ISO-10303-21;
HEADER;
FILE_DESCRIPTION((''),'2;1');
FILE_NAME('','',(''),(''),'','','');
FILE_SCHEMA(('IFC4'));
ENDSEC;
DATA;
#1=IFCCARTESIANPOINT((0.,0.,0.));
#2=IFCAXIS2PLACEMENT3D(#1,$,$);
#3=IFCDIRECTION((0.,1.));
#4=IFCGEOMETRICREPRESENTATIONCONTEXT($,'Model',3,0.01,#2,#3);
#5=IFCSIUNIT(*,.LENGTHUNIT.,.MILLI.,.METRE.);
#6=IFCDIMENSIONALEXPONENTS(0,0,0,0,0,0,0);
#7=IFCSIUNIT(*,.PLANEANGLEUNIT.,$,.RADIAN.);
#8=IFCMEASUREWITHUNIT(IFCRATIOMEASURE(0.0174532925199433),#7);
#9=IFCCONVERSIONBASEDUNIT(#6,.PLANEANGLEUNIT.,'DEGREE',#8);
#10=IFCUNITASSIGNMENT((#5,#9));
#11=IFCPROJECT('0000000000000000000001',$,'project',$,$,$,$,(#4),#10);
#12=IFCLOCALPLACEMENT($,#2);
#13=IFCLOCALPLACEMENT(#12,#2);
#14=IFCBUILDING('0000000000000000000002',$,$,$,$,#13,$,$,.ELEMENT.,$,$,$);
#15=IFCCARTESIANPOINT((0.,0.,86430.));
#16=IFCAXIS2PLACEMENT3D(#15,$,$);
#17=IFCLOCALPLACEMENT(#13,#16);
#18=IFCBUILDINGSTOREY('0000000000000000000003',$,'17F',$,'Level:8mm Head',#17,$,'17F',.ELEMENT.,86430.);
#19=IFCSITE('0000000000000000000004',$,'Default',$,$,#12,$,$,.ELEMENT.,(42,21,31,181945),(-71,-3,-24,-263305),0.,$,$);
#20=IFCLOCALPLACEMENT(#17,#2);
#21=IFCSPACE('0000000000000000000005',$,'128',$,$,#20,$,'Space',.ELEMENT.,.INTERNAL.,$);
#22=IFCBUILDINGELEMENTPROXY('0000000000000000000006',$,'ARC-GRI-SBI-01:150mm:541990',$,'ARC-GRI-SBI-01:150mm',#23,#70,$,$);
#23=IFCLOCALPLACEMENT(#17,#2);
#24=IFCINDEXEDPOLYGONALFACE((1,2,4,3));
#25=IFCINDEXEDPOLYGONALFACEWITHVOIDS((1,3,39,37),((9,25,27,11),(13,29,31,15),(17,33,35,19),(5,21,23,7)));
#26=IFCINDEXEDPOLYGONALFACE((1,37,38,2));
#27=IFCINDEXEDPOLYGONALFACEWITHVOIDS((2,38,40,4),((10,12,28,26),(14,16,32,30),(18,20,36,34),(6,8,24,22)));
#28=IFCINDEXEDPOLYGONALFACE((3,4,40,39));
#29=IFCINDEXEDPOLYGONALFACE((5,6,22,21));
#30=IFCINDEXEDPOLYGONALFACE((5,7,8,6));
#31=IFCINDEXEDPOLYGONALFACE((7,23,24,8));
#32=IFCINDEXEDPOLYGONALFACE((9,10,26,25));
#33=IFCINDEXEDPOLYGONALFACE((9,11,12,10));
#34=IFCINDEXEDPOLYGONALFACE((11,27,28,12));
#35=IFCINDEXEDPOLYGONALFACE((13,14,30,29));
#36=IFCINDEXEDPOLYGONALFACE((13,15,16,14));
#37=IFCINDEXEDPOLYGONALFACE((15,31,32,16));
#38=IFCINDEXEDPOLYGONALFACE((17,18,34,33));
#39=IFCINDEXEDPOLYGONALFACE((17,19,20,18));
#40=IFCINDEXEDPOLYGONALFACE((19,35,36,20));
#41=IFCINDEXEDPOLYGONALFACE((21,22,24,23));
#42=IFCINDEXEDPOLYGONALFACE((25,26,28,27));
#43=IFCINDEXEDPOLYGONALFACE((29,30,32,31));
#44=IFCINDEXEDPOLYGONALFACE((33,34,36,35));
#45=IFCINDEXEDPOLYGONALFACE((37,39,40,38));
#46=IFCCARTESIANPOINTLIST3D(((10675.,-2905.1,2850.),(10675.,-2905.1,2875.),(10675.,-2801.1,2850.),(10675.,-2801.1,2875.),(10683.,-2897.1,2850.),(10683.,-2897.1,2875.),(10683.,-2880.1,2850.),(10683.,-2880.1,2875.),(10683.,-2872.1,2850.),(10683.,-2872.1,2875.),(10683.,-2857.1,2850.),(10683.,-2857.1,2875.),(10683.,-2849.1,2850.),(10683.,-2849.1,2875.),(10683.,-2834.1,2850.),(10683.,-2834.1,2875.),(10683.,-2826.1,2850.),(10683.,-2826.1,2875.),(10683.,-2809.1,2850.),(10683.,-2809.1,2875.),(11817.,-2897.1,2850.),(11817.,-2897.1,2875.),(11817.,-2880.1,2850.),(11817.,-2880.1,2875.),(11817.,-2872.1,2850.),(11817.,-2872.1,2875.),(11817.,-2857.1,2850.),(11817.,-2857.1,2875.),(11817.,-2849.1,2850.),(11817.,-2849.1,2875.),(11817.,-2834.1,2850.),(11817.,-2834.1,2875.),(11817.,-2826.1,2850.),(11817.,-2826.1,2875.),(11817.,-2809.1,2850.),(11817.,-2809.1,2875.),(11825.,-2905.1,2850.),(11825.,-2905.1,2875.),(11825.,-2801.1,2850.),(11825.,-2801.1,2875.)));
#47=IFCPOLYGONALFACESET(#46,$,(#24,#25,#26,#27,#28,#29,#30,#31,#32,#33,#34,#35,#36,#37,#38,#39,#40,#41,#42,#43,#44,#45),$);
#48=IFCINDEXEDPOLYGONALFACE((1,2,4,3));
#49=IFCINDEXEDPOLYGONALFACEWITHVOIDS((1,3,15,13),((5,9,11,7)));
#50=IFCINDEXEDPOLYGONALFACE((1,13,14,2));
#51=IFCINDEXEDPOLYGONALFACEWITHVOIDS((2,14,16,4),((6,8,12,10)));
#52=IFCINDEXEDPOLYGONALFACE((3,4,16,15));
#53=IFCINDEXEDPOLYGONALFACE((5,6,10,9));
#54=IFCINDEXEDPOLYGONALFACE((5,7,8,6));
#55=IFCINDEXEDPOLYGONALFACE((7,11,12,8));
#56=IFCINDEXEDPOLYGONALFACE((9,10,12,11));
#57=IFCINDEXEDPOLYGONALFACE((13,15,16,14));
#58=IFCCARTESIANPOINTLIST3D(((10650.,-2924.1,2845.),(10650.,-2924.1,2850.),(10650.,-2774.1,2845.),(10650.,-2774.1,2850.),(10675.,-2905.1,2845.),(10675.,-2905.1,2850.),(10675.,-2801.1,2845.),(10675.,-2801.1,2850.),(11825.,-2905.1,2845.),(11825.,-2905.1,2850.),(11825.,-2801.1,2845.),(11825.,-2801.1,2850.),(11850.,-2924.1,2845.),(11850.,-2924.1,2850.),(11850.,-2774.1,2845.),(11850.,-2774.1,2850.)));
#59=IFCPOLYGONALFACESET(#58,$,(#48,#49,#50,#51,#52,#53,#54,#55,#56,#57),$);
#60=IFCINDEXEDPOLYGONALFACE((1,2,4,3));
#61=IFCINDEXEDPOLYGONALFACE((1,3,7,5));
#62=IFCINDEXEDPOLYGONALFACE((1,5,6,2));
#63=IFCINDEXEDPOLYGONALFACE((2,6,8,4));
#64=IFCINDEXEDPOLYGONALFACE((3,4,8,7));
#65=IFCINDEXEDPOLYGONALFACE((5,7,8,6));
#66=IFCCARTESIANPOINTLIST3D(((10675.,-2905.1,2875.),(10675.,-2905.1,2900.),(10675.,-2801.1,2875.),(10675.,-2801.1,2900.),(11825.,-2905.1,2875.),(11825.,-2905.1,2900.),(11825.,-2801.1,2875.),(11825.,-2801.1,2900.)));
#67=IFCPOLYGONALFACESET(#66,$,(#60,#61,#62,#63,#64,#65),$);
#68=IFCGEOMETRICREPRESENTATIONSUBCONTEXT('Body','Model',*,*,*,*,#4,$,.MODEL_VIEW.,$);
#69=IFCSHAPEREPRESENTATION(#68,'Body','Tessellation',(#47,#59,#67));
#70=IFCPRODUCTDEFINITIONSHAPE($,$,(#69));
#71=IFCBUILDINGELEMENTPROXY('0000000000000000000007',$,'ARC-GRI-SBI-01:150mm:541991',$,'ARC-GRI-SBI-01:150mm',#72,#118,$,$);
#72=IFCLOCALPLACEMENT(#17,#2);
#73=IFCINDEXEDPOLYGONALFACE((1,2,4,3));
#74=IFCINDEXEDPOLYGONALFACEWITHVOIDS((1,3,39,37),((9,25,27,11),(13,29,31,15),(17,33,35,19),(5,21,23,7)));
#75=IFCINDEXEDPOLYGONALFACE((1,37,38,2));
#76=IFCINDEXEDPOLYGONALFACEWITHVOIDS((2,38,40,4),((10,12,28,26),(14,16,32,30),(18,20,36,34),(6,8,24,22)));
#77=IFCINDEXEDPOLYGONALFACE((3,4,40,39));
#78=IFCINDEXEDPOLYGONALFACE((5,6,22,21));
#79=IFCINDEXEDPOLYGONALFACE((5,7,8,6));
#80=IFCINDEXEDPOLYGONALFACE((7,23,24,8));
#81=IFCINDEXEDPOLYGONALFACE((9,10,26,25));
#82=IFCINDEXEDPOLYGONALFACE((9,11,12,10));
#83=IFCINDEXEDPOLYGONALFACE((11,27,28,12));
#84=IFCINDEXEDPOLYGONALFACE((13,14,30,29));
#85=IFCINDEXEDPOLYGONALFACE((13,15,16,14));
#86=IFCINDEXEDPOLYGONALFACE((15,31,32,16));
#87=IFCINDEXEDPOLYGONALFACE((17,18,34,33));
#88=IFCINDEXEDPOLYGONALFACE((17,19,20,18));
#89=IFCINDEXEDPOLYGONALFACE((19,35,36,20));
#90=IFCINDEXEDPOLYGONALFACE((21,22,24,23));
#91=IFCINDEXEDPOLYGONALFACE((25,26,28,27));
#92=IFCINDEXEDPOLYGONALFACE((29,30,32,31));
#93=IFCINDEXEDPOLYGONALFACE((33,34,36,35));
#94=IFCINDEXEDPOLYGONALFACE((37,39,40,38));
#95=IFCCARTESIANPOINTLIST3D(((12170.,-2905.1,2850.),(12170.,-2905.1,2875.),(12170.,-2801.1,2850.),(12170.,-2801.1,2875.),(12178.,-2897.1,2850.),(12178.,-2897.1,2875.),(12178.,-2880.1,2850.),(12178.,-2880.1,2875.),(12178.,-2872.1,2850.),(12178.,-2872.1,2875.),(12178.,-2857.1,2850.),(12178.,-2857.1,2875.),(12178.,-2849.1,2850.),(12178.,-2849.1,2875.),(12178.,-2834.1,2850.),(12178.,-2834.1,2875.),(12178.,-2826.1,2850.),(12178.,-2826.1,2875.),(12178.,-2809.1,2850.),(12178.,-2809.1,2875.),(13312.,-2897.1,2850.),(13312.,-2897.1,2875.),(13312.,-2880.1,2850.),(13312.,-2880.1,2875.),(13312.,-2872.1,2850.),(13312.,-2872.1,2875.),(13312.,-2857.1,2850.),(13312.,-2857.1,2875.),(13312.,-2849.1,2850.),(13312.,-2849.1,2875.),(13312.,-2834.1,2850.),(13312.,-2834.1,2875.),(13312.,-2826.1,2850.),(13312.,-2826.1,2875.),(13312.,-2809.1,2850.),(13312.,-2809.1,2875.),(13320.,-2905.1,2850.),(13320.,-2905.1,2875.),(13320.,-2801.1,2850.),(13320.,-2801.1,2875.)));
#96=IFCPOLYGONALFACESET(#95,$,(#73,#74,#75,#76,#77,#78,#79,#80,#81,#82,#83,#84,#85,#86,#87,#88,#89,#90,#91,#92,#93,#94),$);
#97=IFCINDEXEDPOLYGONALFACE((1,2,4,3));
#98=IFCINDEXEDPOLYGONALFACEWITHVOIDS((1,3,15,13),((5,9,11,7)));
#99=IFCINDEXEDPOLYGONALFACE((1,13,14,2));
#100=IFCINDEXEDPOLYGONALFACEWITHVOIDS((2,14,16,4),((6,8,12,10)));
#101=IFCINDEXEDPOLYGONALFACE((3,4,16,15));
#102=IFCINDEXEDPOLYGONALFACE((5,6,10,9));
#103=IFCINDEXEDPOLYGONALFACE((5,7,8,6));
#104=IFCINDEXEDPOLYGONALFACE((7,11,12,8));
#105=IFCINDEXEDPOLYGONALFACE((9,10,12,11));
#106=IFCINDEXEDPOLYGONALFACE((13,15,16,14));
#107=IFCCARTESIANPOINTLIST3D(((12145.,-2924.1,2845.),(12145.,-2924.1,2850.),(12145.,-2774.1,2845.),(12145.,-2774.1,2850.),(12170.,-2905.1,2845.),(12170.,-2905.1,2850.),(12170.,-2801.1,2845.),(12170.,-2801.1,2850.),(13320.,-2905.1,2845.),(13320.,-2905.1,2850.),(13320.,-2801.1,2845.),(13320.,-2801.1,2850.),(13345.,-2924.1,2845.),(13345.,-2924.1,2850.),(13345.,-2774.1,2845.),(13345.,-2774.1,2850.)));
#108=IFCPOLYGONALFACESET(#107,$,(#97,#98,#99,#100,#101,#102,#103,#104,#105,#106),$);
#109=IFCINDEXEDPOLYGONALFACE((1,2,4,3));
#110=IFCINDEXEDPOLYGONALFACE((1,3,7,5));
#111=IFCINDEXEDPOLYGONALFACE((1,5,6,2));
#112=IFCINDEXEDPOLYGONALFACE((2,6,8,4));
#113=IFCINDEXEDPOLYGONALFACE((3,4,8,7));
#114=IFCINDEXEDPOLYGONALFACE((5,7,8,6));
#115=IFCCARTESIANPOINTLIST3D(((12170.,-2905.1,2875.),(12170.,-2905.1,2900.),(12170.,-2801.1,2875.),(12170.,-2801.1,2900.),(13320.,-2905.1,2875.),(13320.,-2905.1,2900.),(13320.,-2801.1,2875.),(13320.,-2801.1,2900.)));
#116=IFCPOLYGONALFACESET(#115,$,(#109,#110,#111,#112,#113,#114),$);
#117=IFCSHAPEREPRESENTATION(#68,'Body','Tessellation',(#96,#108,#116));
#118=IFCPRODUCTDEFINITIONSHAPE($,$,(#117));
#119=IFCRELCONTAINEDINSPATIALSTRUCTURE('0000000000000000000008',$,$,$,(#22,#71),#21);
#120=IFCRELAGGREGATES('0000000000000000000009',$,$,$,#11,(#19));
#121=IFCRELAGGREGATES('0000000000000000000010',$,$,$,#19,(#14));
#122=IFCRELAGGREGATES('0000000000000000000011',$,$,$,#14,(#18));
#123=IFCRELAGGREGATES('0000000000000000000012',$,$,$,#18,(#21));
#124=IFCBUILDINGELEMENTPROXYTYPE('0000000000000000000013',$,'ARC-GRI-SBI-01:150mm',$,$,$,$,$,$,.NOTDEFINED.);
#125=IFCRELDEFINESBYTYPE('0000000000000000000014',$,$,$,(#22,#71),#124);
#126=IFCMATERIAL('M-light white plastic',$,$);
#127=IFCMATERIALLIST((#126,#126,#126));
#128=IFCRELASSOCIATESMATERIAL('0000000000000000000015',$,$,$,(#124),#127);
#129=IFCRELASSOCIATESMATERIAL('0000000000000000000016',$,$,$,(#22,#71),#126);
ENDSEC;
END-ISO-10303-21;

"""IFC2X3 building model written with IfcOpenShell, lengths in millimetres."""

from ifc_helpers import new_model, entity, si_unit, converted_unit, direction, frame, origin, origin_2d_with_axis, place, context, subcontext, project, spatial, polyline, rectangle, outline, extrude, source, transform, mapped, material, material_list, type_object, type_shapes, element, save


model = new_model("IFC2X3")

# Units and contexts
model_context = context("Model", 3, precision=0.01, world=origin(), true_north=direction((0.0, 1.0)))
body_context = subcontext(model_context, "Body", "Model", "MODEL_VIEW")
ifc_project = project(units=[si_unit("LENGTHUNIT", "METRE", prefix="MILLI"), converted_unit("PLANEANGLEUNIT", "DEGREE", entity("IfcRatioMeasure", 0.0174532925199433), si_unit("PLANEANGLEUNIT", "RADIAN"), dimensions=[0, 0, 0, 0, 0, 0, 0])], contexts=[model_context])

# Site, building, storey
site_placement = place(None, origin())
site = spatial("IfcSite", under=ifc_project, at=site_placement, Name="Default", CompositionType="ELEMENT", RefLatitude=(42, 21, 31, 181945), RefLongitude=(-71, -3, -24, -263305), RefElevation=0.0)
building_placement = place(site_placement, origin())
building = spatial("IfcBuilding", under=site, at=building_placement, CompositionType="ELEMENT")
storey_placement = place(building_placement, frame((0.0, 0.0, 86430.0)))
storey = spatial("IfcBuildingStorey", under=building, at=storey_placement, Name="17F", ObjectType="Level:8mm Head", LongName="17F", CompositionType="ELEMENT", Elevation=86430.0)

# Shared definitions
space_placement = place(storey_placement, origin())
space = spatial("IfcSpace", under=storey, at=space_placement, Name="128", LongName="Space", CompositionType="ELEMENT", InteriorOrExteriorSpace="INTERNAL")

# Building element proxies
ifc_material_1 = material(Name="M-light white plastic")
ifc_material_list = material_list([ifc_material_1, ifc_material_1, ifc_material_1])
building_element_proxy_type = type_object("IfcBuildingElementProxyType", Name="ARC-GRI-SBI-01:150mm", PredefinedType="NOTDEFINED", material=ifc_material_list)
shared_shape = source(origin(), body_context, "Body", "SweptSolid", [
    extrude(outline(polyline([(-575.0, -52.0), (575.0, -52.0), (575.0, 52.0), (-575.0, 52.0), (-575.0, -52.0)]), holes=[polyline([(-567.0, -44.0), (-567.0, -27.0), (567.0, -27.0), (567.0, -44.0), (-567.0, -44.0)]), polyline([(567.0, -4.0), (567.0, -19.0), (-567.0, -19.0), (-567.0, -4.0), (567.0, -4.0)]), polyline([(-567.0, 44.0), (567.0, 44.0), (567.0, 27.0), (-567.0, 27.0), (-567.0, 44.0)]), polyline([(567.0, 4.0), (-567.0, 4.0), (-567.0, 19.0), (567.0, 19.0), (567.0, 4.0)])]), frame((425.0, 4.0, 4000.0), z_axis=(0.0, 0.0, 1.0), x_axis=(-1.0, 0.0, 0.0)), (0.0, 0.0, 1.0), 25.0),
    extrude(outline(polyline([(-600.0, -75.0), (600.0, -75.0), (600.0, 75.0), (-600.0, 75.0), (-600.0, -75.0)]), holes=[polyline([(-575.0, -56.0), (-575.0, 48.0), (575.0, 48.0), (575.0, -56.0), (-575.0, -56.0)])]), frame((425.0, 0.0, 3995.0), z_axis=(0.0, 0.0, 1.0), x_axis=(-1.0, 0.0, 0.0)), (0.0, 0.0, 1.0), 5.0),
    extrude(rectangle(XDim=1150.0, YDim=104.0, at=origin_2d_with_axis()), frame((425.0, 4.0, 4025.0), z_axis=(0.0, 0.0, 1.0), x_axis=(-1.0, 0.0, 0.0)), (0.0, 0.0, 1.0), 25.0),
])
type_shapes(building_element_proxy_type, [shared_shape])
for number, where, z_axis, x_axis, name in (
    (1, (11675.0, -2849.1, -1150.0), (0.0, 0.0, 1.0), (-1.0, 0.0, 0.0), "ARC-GRI-SBI-01:150mm:541990"),
    (2, (13170.0, -2849.1, -1150.0), (0.0, 0.0, 1.0), (-1.0, 0.0, 0.0), "ARC-GRI-SBI-01:150mm:541991"),
):
    element("IfcBuildingElementProxy", number, at=place(space_placement, frame(where, z_axis=z_axis, x_axis=x_axis)), inside=space, type_object=building_element_proxy_type, material=ifc_material_1, Name=name, ObjectType="ARC-GRI-SBI-01:150mm", context=body_context, shape_type="MappedRepresentation", body=[
        mapped(shared_shape, transform((0.0, 0.0, 0.0), scale=1.0)),
    ])

save(model, "model.ifc")
